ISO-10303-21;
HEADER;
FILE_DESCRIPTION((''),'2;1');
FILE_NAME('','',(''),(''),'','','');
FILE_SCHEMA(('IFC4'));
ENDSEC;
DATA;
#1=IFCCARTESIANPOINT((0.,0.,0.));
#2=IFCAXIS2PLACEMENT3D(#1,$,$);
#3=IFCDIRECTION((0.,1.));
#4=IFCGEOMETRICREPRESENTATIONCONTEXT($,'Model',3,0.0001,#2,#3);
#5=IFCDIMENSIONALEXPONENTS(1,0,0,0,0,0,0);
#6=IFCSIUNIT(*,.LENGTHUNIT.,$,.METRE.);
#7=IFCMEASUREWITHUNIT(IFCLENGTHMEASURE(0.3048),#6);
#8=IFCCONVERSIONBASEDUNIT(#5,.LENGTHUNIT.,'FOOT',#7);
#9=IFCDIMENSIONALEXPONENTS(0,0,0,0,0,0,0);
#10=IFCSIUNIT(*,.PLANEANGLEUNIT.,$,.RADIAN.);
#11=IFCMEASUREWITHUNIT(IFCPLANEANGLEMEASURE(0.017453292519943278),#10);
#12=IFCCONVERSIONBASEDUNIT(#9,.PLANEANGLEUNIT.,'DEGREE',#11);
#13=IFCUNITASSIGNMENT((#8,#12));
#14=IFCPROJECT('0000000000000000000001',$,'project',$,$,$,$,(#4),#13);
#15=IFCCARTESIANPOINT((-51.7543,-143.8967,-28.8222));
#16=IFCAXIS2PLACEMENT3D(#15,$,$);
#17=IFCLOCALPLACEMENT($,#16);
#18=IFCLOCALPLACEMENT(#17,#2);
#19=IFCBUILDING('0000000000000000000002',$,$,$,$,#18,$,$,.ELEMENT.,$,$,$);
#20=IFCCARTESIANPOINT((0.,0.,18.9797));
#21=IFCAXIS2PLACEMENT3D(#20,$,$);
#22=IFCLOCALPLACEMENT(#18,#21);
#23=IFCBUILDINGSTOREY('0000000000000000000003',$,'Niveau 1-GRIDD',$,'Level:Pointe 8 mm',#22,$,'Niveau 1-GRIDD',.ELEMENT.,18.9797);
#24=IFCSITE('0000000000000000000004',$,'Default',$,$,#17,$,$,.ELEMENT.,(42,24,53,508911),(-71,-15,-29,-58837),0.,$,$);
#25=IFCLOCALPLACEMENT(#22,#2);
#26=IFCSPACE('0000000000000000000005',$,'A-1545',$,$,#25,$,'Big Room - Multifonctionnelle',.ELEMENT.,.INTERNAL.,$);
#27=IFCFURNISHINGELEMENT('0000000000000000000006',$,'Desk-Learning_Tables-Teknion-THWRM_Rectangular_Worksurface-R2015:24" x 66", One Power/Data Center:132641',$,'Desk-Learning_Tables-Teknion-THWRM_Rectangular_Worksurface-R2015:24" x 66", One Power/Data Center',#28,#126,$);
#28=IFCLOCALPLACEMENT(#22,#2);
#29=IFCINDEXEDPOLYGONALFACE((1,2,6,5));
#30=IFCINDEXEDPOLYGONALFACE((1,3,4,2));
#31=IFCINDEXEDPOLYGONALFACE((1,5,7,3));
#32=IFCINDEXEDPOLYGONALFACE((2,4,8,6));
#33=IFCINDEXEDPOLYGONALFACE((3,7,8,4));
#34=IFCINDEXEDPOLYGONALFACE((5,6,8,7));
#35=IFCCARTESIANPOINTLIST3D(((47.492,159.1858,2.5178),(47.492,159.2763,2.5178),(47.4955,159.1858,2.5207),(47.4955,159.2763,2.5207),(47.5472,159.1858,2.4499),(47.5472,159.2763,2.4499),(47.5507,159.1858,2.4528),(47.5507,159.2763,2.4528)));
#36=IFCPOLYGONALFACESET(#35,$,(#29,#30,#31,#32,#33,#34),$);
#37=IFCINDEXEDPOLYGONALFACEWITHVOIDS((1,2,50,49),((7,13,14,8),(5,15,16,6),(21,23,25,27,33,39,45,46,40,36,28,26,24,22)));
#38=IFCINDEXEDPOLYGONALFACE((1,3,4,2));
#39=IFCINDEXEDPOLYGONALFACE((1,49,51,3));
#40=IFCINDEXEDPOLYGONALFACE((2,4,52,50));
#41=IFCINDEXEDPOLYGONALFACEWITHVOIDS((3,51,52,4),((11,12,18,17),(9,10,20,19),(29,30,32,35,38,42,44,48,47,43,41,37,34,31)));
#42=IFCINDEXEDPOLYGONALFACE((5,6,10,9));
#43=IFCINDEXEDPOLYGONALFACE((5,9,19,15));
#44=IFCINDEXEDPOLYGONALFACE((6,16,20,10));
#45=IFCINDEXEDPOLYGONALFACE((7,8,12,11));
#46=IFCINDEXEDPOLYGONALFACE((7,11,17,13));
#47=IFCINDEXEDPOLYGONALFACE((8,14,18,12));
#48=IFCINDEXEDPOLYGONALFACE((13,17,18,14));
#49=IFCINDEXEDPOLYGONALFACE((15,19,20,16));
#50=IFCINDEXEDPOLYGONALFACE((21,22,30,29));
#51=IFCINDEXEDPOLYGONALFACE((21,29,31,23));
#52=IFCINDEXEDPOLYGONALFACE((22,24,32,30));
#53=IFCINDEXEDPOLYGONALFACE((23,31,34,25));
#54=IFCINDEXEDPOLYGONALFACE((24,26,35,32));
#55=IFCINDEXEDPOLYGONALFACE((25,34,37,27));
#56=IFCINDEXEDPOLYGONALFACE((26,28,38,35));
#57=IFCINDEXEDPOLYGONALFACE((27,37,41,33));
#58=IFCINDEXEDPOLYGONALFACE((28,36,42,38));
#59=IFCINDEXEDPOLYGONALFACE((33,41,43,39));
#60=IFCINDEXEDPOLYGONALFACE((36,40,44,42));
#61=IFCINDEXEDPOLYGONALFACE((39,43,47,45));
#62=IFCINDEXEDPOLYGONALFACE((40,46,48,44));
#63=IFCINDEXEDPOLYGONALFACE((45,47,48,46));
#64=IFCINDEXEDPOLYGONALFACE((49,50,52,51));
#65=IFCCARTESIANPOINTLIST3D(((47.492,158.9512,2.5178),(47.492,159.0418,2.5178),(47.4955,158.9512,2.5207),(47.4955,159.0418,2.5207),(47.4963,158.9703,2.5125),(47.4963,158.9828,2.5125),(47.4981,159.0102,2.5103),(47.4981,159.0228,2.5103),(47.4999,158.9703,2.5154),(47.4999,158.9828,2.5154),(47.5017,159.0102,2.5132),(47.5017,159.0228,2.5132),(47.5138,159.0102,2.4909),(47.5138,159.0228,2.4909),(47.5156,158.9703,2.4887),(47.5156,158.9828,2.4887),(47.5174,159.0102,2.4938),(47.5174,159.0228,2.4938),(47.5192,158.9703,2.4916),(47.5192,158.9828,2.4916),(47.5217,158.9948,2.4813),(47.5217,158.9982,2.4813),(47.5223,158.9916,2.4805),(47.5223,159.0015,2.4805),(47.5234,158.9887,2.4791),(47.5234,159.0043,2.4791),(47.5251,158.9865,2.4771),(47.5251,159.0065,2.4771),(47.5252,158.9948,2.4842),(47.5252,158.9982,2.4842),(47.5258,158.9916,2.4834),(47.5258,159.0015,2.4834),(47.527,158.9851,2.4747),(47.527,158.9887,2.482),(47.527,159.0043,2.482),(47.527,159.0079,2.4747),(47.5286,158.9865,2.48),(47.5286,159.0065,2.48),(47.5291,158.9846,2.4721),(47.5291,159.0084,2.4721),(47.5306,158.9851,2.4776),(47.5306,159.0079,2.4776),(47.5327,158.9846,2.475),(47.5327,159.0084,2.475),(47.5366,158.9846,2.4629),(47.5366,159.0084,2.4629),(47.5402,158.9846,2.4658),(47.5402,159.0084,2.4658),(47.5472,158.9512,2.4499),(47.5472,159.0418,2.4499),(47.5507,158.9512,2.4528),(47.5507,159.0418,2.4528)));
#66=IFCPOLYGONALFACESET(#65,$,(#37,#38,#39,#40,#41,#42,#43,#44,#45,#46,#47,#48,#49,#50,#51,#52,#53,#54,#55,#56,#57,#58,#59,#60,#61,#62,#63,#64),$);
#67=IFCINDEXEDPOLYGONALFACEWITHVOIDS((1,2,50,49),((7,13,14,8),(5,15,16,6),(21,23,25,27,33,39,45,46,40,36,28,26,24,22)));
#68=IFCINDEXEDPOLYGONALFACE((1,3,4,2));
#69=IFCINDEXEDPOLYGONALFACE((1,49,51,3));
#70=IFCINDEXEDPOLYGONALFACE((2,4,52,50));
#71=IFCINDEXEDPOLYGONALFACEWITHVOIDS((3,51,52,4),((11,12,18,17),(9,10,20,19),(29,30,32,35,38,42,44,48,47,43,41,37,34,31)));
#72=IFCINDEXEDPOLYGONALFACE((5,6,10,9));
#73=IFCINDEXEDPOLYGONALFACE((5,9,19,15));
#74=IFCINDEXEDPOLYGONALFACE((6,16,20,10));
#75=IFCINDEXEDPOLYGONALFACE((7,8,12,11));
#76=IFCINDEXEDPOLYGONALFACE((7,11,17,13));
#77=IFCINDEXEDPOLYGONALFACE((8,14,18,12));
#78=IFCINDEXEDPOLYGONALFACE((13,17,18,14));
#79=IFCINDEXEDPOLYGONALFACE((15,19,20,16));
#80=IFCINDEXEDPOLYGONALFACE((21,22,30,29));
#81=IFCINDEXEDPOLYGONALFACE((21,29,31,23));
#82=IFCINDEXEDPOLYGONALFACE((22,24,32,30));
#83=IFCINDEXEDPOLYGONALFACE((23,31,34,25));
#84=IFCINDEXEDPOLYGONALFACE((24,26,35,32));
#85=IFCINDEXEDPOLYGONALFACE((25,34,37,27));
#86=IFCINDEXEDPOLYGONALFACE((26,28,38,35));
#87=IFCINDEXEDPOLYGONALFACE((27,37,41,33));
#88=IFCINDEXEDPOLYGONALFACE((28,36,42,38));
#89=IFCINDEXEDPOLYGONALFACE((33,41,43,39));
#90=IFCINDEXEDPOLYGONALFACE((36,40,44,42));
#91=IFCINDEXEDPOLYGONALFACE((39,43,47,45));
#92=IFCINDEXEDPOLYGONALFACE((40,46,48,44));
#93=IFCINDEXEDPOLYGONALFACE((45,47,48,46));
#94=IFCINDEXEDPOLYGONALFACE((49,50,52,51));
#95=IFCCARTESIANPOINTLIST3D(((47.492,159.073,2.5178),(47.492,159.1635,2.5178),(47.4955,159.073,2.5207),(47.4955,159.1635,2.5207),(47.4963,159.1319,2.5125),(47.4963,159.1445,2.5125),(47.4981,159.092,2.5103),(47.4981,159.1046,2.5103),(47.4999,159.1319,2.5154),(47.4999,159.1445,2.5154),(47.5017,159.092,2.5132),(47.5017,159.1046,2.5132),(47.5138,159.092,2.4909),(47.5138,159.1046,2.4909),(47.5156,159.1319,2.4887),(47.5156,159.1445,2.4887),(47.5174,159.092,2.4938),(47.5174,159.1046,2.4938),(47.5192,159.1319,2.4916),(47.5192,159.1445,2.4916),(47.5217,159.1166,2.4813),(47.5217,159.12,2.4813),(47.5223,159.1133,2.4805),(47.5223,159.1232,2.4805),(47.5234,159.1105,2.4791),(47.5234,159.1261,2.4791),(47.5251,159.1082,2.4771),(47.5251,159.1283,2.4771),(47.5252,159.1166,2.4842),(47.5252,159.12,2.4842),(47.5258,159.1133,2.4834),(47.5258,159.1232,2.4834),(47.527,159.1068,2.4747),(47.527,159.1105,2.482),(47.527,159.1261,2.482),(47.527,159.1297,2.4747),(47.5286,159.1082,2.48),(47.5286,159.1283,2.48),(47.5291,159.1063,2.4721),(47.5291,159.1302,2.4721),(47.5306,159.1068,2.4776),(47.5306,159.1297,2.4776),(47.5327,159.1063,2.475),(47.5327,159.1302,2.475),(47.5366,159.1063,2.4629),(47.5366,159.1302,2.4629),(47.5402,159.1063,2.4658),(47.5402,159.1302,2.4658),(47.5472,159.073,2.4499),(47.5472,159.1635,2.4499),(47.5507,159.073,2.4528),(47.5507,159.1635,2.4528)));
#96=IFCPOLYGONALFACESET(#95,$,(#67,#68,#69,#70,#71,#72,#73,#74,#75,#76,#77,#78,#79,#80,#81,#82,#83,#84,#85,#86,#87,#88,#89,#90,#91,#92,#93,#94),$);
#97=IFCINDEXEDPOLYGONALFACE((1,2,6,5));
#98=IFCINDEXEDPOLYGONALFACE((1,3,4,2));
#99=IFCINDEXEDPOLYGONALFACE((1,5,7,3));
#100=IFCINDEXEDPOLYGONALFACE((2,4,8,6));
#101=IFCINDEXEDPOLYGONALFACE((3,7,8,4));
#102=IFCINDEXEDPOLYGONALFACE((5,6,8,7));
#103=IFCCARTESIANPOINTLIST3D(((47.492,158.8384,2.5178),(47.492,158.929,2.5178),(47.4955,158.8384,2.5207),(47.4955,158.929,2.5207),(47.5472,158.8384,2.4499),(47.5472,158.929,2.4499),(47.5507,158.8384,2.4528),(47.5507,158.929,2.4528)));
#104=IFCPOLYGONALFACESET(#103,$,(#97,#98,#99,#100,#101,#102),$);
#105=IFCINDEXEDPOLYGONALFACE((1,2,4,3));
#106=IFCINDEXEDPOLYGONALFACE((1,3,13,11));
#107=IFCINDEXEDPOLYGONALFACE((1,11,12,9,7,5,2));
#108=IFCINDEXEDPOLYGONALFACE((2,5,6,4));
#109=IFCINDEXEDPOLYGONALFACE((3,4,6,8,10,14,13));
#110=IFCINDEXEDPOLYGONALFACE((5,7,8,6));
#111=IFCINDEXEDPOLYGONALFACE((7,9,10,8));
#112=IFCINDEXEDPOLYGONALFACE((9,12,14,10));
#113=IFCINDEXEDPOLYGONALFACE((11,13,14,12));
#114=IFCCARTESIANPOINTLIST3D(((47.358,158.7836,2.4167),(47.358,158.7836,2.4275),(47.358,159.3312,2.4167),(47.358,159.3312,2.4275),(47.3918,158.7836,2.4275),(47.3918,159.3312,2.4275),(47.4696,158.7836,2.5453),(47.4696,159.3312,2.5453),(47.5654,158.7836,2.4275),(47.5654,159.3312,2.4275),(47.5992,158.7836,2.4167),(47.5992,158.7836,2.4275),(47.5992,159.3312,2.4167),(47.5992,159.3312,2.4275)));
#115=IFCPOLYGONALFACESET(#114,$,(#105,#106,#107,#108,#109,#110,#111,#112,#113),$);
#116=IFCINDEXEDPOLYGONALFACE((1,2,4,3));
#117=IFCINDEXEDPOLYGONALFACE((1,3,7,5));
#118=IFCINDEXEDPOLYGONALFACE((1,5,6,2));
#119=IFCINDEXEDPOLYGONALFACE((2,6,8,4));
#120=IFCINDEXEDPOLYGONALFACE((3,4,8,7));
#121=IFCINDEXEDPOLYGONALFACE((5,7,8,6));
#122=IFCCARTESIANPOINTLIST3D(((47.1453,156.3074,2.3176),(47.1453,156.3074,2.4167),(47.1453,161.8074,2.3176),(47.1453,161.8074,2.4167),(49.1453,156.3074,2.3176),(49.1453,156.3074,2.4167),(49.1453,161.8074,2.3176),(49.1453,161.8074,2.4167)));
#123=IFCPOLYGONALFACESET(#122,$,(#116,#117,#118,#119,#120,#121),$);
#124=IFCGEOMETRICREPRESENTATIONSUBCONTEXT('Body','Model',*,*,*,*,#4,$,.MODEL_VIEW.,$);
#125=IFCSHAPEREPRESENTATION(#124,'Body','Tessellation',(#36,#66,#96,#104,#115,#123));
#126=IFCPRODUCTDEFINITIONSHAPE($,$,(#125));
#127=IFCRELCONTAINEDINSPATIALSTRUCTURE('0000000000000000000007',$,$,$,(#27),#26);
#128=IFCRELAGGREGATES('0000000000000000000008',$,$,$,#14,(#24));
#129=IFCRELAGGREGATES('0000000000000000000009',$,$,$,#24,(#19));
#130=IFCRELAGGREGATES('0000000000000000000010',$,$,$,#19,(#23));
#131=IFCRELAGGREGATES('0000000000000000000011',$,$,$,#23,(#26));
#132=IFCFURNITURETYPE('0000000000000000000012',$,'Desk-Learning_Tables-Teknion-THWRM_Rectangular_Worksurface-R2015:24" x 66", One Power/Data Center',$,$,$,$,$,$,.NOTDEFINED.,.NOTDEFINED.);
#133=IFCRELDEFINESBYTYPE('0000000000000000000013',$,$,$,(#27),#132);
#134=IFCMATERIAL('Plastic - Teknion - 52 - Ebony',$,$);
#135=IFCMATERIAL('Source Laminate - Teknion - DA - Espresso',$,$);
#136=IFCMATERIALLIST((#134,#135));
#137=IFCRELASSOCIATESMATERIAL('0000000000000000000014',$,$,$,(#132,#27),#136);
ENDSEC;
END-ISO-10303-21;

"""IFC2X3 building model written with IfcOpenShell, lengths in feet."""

from ifc_helpers import new_model, entity, si_unit, converted_unit, direction, frame, frame_2d, origin, place, context, subcontext, project, spatial, polyline, circle_curve, parameter, trimmed, segment, composite_curve, rectangle, outline, extrude, source, transform, mapped, material, material_list, type_object, type_shapes, element, save


model = new_model("IFC2X3")

# Units and contexts
model_context = context("Model", 3, precision=0.0001, world=origin(), true_north=direction((0.0, 1.0)))
body_context = subcontext(model_context, "Body", "Model", "MODEL_VIEW")
ifc_project = project(units=[converted_unit("LENGTHUNIT", "FOOT", entity("IfcLengthMeasure", 0.3048), si_unit("LENGTHUNIT", "METRE"), dimensions=[1, 0, 0, 0, 0, 0, 0]), converted_unit("PLANEANGLEUNIT", "DEGREE", entity("IfcPlaneAngleMeasure", 0.017453292519943278), si_unit("PLANEANGLEUNIT", "RADIAN"), dimensions=[0, 0, 0, 0, 0, 0, 0])], contexts=[model_context])

# Site, building, storey
site_placement = place(None, frame((-51.7543, -143.8967, -28.8222)))
site = spatial("IfcSite", under=ifc_project, at=site_placement, Name="Default", CompositionType="ELEMENT", RefLatitude=(42, 24, 53, 508911), RefLongitude=(-71, -15, -29, -58837), RefElevation=0.0)
building_placement = place(site_placement, origin())
building = spatial("IfcBuilding", under=site, at=building_placement, CompositionType="ELEMENT")
storey_placement = place(building_placement, frame((0.0, 0.0, 18.9797)))
storey = spatial("IfcBuildingStorey", under=building, at=storey_placement, Name="Niveau 1-GRIDD", ObjectType="Level:Pointe 8 mm", LongName="Niveau 1-GRIDD", CompositionType="ELEMENT", Elevation=18.9797)

# Shared definitions
space_1_placement = place(storey_placement, origin())
space_1 = spatial("IfcSpace", under=storey, at=space_1_placement, Name="A-1545", LongName="Big Room - Multifonctionnelle", CompositionType="ELEMENT", InteriorOrExteriorSpace="INTERNAL")

# Furnishing element
ifc_material_1 = material(Name="Plastic - Teknion - 52 - Ebony")
ifc_material_2 = material(Name="Source Laminate - Teknion - DA - Espresso")
ifc_material_list_1 = material_list([ifc_material_1, ifc_material_2])
furniture_type_1 = type_object("IfcFurnitureType", Name="Desk-Learning_Tables-Teknion-THWRM_Rectangular_Worksurface-R2015:24\" x 66\", One Power/Data Center", AssemblyPlace="NOTDEFINED", material=ifc_material_list_1)
shared_shape_1 = source(origin(), body_context, "Body", "SweptSolid", [
    extrude(rectangle(XDim=0.0875, YDim=0.0046, at=frame_2d((0.0, 0.0), x_axis=(0.0, 1.0))), frame((0.1284, 0.6239, 2.4853), z_axis=(1.0, 0.0, 0.0), x_axis=(0.0, 0.776046, -0.630676)), (0.0, 0.0, 1.0), 0.0906),
    extrude(outline(polyline([(-0.0453, -0.0438), (0.0453, -0.0438), (0.0453, 0.0438), (-0.0453, 0.0438), (-0.0453, -0.0438)]), holes=[polyline([(-0.0262, -0.0063), (-0.0137, -0.0063), (-0.0137, -0.0369), (-0.0262, -0.0369), (-0.0262, -0.0063)]), polyline([(0.0137, -0.0341), (0.0137, -0.0091), (0.0262, -0.0091), (0.0262, -0.0341), (0.0137, -0.0341)]), composite_curve([segment(polyline([(-0.0119, 0.027), (0.0119, 0.027)]), True, "CONTINUOUS"), segment(polyline([(0.0119, 0.027), (0.0119, 0.0151)]), True, "CONTINUOUS"), segment(trimmed(circle_curve(frame_2d((0.0, 0.0151), x_axis=(0.0, -1.0)), 0.0119), [parameter(270.0)], [parameter(90.0)], True, "PARAMETER"), False, "CONTINUOUS"), segment(polyline([(-0.0119, 0.0151), (-0.0119, 0.027)]), True, "CONTINUOUS")], self_intersect=False)]), frame((-0.0609, 0.6221, 2.4867), z_axis=(0.0, 0.776046, -0.630676), x_axis=(1.0, 0.0, 0.0)), (0.0, 0.0, 1.0), 0.0046),
    extrude(outline(polyline([(-0.0438, -0.0453), (0.0438, -0.0453), (0.0438, 0.0453), (-0.0438, 0.0453), (-0.0438, -0.0453)]), holes=[polyline([(-0.0063, -0.0262), (-0.0369, -0.0262), (-0.0369, -0.0137), (-0.0063, -0.0137), (-0.0063, -0.0262)]), polyline([(-0.0341, 0.0137), (-0.0341, 0.0262), (-0.0091, 0.0262), (-0.0091, 0.0137), (-0.0341, 0.0137)]), composite_curve([segment(polyline([(0.027, -0.0119), (0.0151, -0.0119)]), True, "CONTINUOUS"), segment(trimmed(circle_curve(frame_2d((0.0151, 0.0), x_axis=(-1.0, 0.0)), 0.0119), [parameter(270.0)], [parameter(90.0)], True, "PARAMETER"), False, "CONTINUOUS"), segment(polyline([(0.0151, 0.0119), (0.027, 0.0119)]), True, "CONTINUOUS"), segment(polyline([(0.027, 0.0119), (0.027, -0.0119)]), True, "CONTINUOUS")], self_intersect=False)]), frame((0.0609, 0.6221, 2.4867), z_axis=(0.0, 0.776046, -0.630676), x_axis=(0.0, -0.630676, -0.776046)), (0.0, 0.0, 1.0), 0.0046),
    extrude(rectangle(XDim=0.0875, YDim=0.0046, at=frame_2d((0.0, 0.0), x_axis=(0.0, 1.0))), frame((-0.219, 0.6239, 2.4853), z_axis=(1.0, 0.0, 0.0), x_axis=(0.0, 0.776046, -0.630676)), (0.0, 0.0, 1.0), 0.0906),
    extrude(outline(polyline([(-0.0586, -0.0638), (0.0826, -0.0638), (0.0371, 0.0811), (0.0557, 0.1093), (0.0467, 0.1152), (-0.0862, -0.086), (-0.0772, -0.092), (-0.0586, -0.0638)])), frame((-0.2738, 0.6679, 2.4412), z_axis=(1.0, 0.0, 0.0), x_axis=(0.0, -0.551103, 0.834437)), (0.0, 0.0, 1.0), 0.5475),
    extrude(rectangle(XDim=5.5, YDim=2.0, at=frame_2d((0.0, 0.0), x_axis=(1.0, 0.0))), frame((0.0, 0.0, 2.3176), z_axis=(0.0, 0.0, 1.0), x_axis=(-1.0, 0.0, 0.0)), (0.0, 0.0, 1.0), 0.0991),
])
type_shapes(furniture_type_1, [shared_shape_1])
for number, where, z_axis, x_axis, name in (
    (1, (48.1453, 159.0574, 0.0), (0.0, 0.0, 1.0), (0.0, 1.0, 0.0), "Desk-Learning_Tables-Teknion-THWRM_Rectangular_Worksurface-R2015:24\" x 66\", One Power/Data Center:132641"),
):
    element("IfcFurnishingElement", number, at=place(space_1_placement, frame(where, z_axis=z_axis, x_axis=x_axis)), inside=space_1, type_object=furniture_type_1, material=ifc_material_list_1, Name=name, ObjectType="Desk-Learning_Tables-Teknion-THWRM_Rectangular_Worksurface-R2015:24\" x 66\", One Power/Data Center", context=body_context, shape_type="MappedRepresentation", body=[
        mapped(shared_shape_1, transform((0.0, 0.0, 0.0), scale=1.0)),
    ])

save(model, "model.ifc")
